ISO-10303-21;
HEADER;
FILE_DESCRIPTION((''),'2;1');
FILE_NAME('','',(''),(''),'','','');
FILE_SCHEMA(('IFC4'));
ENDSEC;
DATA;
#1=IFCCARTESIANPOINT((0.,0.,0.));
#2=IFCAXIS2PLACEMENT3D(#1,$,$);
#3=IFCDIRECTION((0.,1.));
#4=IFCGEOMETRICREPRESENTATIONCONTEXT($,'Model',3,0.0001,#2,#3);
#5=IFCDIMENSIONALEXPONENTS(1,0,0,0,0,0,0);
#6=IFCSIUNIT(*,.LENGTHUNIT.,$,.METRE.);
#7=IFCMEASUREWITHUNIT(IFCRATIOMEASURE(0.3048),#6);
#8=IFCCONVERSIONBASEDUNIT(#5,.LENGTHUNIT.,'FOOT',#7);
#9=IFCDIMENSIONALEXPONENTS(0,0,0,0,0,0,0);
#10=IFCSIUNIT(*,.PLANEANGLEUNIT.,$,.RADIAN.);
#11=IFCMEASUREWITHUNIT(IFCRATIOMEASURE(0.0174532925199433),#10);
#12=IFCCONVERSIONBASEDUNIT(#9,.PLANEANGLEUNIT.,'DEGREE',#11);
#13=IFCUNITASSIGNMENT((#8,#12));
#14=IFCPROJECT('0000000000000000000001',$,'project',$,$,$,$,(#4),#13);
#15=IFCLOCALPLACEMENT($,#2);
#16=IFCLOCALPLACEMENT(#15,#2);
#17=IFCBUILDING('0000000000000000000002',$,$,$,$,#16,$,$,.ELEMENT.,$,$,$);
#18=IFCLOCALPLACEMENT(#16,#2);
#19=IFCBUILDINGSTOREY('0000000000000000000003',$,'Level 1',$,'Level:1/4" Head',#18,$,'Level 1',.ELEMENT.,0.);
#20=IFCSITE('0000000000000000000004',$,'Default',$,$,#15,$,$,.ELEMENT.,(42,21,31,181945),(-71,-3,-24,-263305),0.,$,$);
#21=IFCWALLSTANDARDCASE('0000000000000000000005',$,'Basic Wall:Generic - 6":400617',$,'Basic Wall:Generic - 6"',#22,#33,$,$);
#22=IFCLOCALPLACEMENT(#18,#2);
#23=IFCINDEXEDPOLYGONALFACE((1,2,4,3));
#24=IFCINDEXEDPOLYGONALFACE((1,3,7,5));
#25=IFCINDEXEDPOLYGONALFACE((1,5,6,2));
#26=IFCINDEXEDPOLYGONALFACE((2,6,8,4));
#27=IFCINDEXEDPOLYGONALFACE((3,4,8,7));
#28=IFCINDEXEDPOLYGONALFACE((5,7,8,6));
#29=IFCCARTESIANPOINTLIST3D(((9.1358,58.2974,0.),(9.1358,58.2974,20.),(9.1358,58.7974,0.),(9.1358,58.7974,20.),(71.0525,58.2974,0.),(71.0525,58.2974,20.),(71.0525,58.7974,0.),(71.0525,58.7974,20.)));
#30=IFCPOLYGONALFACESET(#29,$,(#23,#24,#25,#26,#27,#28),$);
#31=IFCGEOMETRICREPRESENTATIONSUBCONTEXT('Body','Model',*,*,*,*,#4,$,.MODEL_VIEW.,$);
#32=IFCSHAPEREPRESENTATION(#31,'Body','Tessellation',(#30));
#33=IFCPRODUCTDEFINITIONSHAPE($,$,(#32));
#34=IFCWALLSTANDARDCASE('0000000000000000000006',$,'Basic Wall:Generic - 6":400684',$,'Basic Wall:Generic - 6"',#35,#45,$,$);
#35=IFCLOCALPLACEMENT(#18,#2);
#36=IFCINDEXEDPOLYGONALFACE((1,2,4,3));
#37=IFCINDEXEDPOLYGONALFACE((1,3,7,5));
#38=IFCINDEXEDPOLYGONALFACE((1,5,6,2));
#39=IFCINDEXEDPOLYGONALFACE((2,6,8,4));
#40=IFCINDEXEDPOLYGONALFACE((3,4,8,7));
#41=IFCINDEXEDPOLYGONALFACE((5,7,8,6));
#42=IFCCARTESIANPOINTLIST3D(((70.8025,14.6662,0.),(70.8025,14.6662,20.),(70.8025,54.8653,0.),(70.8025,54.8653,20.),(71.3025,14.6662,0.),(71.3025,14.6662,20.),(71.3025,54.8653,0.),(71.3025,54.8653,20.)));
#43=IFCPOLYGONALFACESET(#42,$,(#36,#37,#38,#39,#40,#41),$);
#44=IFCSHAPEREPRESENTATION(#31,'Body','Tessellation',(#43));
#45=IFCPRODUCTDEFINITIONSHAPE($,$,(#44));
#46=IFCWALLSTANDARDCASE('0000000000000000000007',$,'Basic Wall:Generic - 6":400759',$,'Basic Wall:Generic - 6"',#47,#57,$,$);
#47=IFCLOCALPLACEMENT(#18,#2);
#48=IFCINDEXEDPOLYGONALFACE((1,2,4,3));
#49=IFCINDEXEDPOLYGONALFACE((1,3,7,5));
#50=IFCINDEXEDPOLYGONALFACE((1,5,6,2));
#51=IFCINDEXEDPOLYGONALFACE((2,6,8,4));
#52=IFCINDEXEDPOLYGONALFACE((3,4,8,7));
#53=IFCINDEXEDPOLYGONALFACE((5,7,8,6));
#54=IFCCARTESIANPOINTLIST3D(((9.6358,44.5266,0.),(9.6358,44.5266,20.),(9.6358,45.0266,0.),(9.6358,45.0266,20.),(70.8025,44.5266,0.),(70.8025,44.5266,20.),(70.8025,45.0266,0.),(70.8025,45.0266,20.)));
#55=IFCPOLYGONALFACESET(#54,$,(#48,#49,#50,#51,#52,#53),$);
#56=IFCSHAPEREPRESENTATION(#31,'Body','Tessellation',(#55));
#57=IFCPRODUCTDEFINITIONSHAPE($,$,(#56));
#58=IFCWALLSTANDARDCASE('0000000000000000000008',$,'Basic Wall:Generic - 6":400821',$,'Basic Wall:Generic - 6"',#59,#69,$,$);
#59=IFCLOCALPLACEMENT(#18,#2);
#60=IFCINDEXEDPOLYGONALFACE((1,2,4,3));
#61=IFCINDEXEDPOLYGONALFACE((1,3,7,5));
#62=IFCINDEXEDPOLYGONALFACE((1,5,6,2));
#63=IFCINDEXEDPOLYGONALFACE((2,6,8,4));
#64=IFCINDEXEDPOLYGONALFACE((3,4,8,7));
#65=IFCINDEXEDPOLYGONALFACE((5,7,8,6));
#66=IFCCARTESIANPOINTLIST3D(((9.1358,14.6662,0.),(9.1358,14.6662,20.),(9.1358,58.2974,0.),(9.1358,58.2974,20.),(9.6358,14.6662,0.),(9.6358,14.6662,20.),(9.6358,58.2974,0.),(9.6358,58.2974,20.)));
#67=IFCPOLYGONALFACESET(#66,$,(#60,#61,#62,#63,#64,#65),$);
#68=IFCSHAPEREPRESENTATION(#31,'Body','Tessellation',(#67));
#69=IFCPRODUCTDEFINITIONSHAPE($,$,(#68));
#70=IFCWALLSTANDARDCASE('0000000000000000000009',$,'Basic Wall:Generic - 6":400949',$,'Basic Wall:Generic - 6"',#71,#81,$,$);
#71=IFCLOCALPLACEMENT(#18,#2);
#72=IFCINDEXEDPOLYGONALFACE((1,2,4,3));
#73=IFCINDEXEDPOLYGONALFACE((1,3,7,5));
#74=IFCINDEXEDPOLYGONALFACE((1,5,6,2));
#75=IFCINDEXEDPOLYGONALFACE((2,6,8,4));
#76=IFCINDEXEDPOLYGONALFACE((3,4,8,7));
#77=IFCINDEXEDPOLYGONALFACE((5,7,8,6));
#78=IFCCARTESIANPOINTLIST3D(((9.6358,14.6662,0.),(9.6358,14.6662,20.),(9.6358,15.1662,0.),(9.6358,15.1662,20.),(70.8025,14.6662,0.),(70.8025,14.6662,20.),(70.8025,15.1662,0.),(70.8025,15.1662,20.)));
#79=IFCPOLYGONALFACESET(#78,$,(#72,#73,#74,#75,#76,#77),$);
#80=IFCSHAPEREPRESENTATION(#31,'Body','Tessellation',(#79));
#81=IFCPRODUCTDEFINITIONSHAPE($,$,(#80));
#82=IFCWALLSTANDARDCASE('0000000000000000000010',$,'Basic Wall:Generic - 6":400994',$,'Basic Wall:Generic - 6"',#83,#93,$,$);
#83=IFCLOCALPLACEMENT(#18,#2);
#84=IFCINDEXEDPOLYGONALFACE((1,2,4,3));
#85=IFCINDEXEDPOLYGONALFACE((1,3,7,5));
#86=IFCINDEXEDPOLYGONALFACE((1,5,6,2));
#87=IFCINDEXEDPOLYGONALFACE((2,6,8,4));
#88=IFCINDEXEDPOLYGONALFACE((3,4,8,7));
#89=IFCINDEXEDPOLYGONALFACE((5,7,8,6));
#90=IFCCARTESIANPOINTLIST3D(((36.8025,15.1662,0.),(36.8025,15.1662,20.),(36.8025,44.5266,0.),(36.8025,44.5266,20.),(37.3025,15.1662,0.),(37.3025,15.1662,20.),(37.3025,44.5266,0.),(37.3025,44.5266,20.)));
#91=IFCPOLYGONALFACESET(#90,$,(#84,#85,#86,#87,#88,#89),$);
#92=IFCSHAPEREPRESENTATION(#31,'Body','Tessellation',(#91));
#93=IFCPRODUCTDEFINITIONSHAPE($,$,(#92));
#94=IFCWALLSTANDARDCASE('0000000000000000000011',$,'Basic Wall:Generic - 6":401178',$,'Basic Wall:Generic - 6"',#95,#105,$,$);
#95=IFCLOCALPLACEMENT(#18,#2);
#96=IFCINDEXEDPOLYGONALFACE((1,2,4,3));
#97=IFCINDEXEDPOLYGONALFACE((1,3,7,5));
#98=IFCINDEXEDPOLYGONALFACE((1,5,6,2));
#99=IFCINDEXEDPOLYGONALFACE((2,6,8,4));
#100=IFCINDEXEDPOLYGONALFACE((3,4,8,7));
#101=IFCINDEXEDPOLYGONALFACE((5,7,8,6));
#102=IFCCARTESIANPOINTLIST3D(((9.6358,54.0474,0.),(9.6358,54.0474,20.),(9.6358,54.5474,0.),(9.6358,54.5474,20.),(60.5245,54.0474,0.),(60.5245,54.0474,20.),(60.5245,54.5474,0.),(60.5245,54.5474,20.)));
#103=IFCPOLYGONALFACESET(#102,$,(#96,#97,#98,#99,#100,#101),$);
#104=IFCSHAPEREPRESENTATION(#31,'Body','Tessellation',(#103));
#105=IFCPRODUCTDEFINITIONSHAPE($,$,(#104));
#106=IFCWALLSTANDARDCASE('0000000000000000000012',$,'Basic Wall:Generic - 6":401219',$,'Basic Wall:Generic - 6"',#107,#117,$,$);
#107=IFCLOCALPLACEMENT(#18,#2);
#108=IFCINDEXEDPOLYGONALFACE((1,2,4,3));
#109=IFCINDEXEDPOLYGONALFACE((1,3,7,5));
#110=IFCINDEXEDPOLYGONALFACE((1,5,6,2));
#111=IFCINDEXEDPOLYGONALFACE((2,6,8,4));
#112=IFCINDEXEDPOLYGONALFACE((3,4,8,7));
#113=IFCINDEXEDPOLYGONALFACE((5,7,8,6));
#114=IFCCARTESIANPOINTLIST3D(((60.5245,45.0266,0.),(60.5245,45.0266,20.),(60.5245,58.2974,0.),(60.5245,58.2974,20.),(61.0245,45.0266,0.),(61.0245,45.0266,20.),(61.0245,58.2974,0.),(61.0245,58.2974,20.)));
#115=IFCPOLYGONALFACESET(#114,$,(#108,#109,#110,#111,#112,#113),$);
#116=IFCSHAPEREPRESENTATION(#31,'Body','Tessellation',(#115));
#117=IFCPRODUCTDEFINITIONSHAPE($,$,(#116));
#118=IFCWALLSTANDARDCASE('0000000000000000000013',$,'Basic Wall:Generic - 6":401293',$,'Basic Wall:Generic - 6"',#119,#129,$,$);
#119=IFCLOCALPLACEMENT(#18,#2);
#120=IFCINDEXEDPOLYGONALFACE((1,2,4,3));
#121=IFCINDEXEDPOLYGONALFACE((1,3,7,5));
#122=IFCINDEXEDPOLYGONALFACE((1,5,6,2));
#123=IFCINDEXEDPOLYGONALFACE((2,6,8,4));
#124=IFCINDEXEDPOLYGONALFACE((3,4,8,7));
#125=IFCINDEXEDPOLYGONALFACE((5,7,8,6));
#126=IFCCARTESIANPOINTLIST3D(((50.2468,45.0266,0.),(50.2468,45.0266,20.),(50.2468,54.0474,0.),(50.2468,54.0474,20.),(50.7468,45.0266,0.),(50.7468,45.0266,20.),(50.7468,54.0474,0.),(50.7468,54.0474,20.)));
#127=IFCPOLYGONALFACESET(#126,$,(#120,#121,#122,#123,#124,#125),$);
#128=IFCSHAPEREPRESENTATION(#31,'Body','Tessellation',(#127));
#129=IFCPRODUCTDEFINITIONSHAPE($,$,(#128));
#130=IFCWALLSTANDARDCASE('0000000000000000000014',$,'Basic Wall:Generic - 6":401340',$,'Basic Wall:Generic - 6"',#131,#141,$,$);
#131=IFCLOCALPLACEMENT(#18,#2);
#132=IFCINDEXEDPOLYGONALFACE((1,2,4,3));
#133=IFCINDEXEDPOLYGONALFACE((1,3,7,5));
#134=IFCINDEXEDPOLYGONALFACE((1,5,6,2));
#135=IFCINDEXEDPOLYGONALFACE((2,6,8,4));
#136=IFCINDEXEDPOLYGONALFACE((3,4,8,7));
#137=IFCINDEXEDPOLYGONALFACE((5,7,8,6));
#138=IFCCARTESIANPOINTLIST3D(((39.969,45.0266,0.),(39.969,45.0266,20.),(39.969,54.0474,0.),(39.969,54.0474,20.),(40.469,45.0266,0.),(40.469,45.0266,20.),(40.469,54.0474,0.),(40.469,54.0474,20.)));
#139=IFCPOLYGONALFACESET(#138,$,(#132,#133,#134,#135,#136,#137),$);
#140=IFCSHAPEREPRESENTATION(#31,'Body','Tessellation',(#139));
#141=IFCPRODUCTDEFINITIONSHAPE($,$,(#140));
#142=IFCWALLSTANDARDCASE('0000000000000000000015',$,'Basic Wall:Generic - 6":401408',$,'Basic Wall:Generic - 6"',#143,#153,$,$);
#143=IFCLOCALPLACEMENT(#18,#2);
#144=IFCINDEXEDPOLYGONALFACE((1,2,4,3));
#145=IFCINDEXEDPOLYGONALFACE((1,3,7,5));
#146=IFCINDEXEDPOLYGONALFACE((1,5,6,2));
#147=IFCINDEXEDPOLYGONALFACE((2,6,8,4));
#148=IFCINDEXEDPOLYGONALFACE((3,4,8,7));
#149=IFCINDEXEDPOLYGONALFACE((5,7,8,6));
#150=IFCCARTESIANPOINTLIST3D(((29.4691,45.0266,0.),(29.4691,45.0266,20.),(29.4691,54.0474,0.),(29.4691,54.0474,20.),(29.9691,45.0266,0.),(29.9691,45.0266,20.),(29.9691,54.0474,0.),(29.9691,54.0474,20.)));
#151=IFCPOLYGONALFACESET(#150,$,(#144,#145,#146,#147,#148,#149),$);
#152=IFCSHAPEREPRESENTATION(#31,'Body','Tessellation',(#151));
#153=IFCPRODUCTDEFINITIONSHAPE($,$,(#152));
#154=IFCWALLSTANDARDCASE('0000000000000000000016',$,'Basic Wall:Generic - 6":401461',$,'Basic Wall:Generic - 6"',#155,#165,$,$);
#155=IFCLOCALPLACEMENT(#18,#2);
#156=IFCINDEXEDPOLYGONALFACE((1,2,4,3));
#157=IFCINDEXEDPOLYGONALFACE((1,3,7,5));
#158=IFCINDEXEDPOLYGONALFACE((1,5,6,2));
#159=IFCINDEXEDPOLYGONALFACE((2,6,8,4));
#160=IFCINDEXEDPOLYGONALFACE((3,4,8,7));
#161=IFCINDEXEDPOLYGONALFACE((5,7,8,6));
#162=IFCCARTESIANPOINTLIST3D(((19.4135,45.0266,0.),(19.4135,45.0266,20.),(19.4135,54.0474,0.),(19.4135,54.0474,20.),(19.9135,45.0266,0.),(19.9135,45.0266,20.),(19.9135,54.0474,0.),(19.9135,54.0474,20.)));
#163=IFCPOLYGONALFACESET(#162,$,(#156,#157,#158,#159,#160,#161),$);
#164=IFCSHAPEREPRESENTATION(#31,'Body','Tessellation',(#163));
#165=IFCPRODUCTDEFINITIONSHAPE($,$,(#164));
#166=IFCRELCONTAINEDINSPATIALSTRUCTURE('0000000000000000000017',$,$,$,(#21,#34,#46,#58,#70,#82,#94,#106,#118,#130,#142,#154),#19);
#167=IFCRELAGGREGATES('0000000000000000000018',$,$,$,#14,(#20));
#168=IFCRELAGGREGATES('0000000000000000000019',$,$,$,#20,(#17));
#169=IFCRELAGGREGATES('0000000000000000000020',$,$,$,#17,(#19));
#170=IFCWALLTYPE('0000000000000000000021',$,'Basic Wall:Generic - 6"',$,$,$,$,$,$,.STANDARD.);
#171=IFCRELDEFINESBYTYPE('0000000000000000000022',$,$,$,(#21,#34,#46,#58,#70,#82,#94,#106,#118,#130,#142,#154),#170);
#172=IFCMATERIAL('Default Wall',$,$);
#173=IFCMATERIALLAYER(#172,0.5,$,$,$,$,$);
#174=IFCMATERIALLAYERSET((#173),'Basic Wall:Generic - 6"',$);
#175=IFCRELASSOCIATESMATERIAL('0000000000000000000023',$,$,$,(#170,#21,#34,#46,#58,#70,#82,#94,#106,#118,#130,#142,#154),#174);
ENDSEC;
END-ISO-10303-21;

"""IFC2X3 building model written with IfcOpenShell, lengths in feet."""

from ifc_helpers import new_model, entity, si_unit, converted_unit, direction, frame, frame_2d, origin, place, context, subcontext, project, spatial, rectangle, extrude, material, layer, layer_set, layer_usage, type_object, element, save


model = new_model("IFC2X3")

# Units and contexts
model_context = context("Model", 3, precision=0.0001, world=origin(), true_north=direction((0.0, 1.0)))
body_context = subcontext(model_context, "Body", "Model", "MODEL_VIEW")
ifc_project = project(units=[converted_unit("LENGTHUNIT", "FOOT", entity("IfcRatioMeasure", 0.3048), si_unit("LENGTHUNIT", "METRE"), dimensions=[1, 0, 0, 0, 0, 0, 0]), converted_unit("PLANEANGLEUNIT", "DEGREE", entity("IfcRatioMeasure", 0.0174532925199433), si_unit("PLANEANGLEUNIT", "RADIAN"), dimensions=[0, 0, 0, 0, 0, 0, 0])], contexts=[model_context])

# Site, building, storey
site_placement = place(None, origin())
site = spatial("IfcSite", under=ifc_project, at=site_placement, Name="Default", CompositionType="ELEMENT", RefLatitude=(42, 21, 31, 181945), RefLongitude=(-71, -3, -24, -263305), RefElevation=0.0)
building_placement = place(site_placement, origin())
building = spatial("IfcBuilding", under=site, at=building_placement, CompositionType="ELEMENT")
storey_placement = place(building_placement, origin())
storey = spatial("IfcBuildingStorey", under=building, at=storey_placement, Name="Level 1", ObjectType="Level:1/4\" Head", LongName="Level 1", CompositionType="ELEMENT", Elevation=0.0)

# Walls
ifc_material = material(Name="Default Wall")
ifc_layer = layer(ifc_material, 0.5)
ifc_layer_set = layer_set([ifc_layer], Name="Basic Wall:Generic - 6\"")
wall_type = type_object("IfcWallType", Name="Basic Wall:Generic - 6\"", PredefinedType="STANDARD", material=ifc_layer_set)
ifc_layer_usage_1 = layer_usage(ifc_layer_set, "AXIS2", "NEGATIVE", 0.25)
wall_1_placement = place(storey_placement, frame((9.1358, 58.5474, 0.0)))
element("IfcWallStandardCase", 1, at=wall_1_placement, inside=storey, type_object=wall_type, material=ifc_layer_usage_1, Name="Basic Wall:Generic - 6\":400617", ObjectType="Basic Wall:Generic - 6\"", context=body_context, shape_type="SweptSolid", body=[
    extrude(rectangle(XDim=61.9167, YDim=0.5, at=frame_2d((30.9583, 0.0), x_axis=(-1.0, 0.0))), origin(), (0.0, 0.0, 1.0), 20.0),
])
ifc_layer_usage_2 = layer_usage(ifc_layer_set, "AXIS2", "NEGATIVE", 0.25)
wall_2_placement = place(storey_placement, frame((71.0525, 54.8653, 0.0), z_axis=(0.0, 0.0, 1.0), x_axis=(0.0, -1.0, 0.0)))
element("IfcWallStandardCase", 2, at=wall_2_placement, inside=storey, type_object=wall_type, material=ifc_layer_usage_2, Name="Basic Wall:Generic - 6\":400684", ObjectType="Basic Wall:Generic - 6\"", context=body_context, shape_type="SweptSolid", body=[
    extrude(rectangle(XDim=40.1991, YDim=0.5, at=frame_2d((20.0995, 0.0), x_axis=(-1.0, 0.0))), origin(), (0.0, 0.0, 1.0), 20.0),
])
ifc_layer_usage_3 = layer_usage(ifc_layer_set, "AXIS2", "NEGATIVE", 0.25)
wall_3_placement = place(storey_placement, frame((70.8025, 44.7766, 0.0), z_axis=(0.0, 0.0, 1.0), x_axis=(-1.0, 0.0, 0.0)))
element("IfcWallStandardCase", 3, at=wall_3_placement, inside=storey, type_object=wall_type, material=ifc_layer_usage_3, Name="Basic Wall:Generic - 6\":400759", ObjectType="Basic Wall:Generic - 6\"", context=body_context, shape_type="SweptSolid", body=[
    extrude(rectangle(XDim=61.1667, YDim=0.5, at=frame_2d((30.5833, 0.0), x_axis=(-1.0, 0.0))), origin(), (0.0, 0.0, 1.0), 20.0),
])
ifc_layer_usage_4 = layer_usage(ifc_layer_set, "AXIS2", "NEGATIVE", 0.25)
wall_4_placement = place(storey_placement, frame((9.3858, 14.6662, 0.0), z_axis=(0.0, 0.0, 1.0), x_axis=(0.0, 1.0, 0.0)))
element("IfcWallStandardCase", 4, at=wall_4_placement, inside=storey, type_object=wall_type, material=ifc_layer_usage_4, Name="Basic Wall:Generic - 6\":400821", ObjectType="Basic Wall:Generic - 6\"", context=body_context, shape_type="SweptSolid", body=[
    extrude(rectangle(XDim=43.6312, YDim=0.5, at=frame_2d((21.8156, 0.0), x_axis=(-1.0, 0.0))), origin(), (0.0, 0.0, 1.0), 20.0),
])
ifc_layer_usage_5 = layer_usage(ifc_layer_set, "AXIS2", "NEGATIVE", 0.25)
wall_5_placement = place(storey_placement, frame((9.6358, 14.9162, 0.0)))
element("IfcWallStandardCase", 5, at=wall_5_placement, inside=storey, type_object=wall_type, material=ifc_layer_usage_5, Name="Basic Wall:Generic - 6\":400949", ObjectType="Basic Wall:Generic - 6\"", context=body_context, shape_type="SweptSolid", body=[
    extrude(rectangle(XDim=61.1667, YDim=0.5, at=frame_2d((30.5833, 0.0), x_axis=(-1.0, 0.0))), origin(), (0.0, 0.0, 1.0), 20.0),
])
ifc_layer_usage_6 = layer_usage(ifc_layer_set, "AXIS2", "NEGATIVE", 0.25)
wall_6_placement = place(storey_placement, frame((37.0525, 15.1662, 0.0), z_axis=(0.0, 0.0, 1.0), x_axis=(0.0, 1.0, 0.0)))
element("IfcWallStandardCase", 6, at=wall_6_placement, inside=storey, type_object=wall_type, material=ifc_layer_usage_6, Name="Basic Wall:Generic - 6\":400994", ObjectType="Basic Wall:Generic - 6\"", context=body_context, shape_type="SweptSolid", body=[
    extrude(rectangle(XDim=29.3604, YDim=0.5, at=frame_2d((14.6802, 0.0), x_axis=(-1.0, 0.0))), origin(), (0.0, 0.0, 1.0), 20.0),
])
ifc_layer_usage_7 = layer_usage(ifc_layer_set, "AXIS2", "NEGATIVE", 0.25)
wall_7_placement = place(storey_placement, frame((9.6358, 54.2974, 0.0)))
element("IfcWallStandardCase", 7, at=wall_7_placement, inside=storey, type_object=wall_type, material=ifc_layer_usage_7, Name="Basic Wall:Generic - 6\":401178", ObjectType="Basic Wall:Generic - 6\"", context=body_context, shape_type="SweptSolid", body=[
    extrude(rectangle(XDim=50.8888, YDim=0.5, at=frame_2d((25.4444, 0.0), x_axis=(-1.0, 0.0))), origin(), (0.0, 0.0, 1.0), 20.0),
])
ifc_layer_usage_8 = layer_usage(ifc_layer_set, "AXIS2", "NEGATIVE", 0.25)
wall_8_placement = place(storey_placement, frame((60.7745, 58.2974, 0.0), z_axis=(0.0, 0.0, 1.0), x_axis=(0.0, -1.0, 0.0)))
element("IfcWallStandardCase", 8, at=wall_8_placement, inside=storey, type_object=wall_type, material=ifc_layer_usage_8, Name="Basic Wall:Generic - 6\":401219", ObjectType="Basic Wall:Generic - 6\"", context=body_context, shape_type="SweptSolid", body=[
    extrude(rectangle(XDim=13.2708, YDim=0.5, at=frame_2d((6.6354, 0.0), x_axis=(-1.0, 0.0))), origin(), (0.0, 0.0, 1.0), 20.0),
])
ifc_layer_usage_9 = layer_usage(ifc_layer_set, "AXIS2", "NEGATIVE", 0.25)
wall_9_placement = place(storey_placement, frame((50.4968, 45.0266, 0.0), z_axis=(0.0, 0.0, 1.0), x_axis=(0.0, 1.0, 0.0)))
element("IfcWallStandardCase", 9, at=wall_9_placement, inside=storey, type_object=wall_type, material=ifc_layer_usage_9, Name="Basic Wall:Generic - 6\":401293", ObjectType="Basic Wall:Generic - 6\"", context=body_context, shape_type="SweptSolid", body=[
    extrude(rectangle(XDim=9.0208, YDim=0.5, at=frame_2d((4.5104, 0.0), x_axis=(-1.0, 0.0))), origin(), (0.0, 0.0, 1.0), 20.0),
])
ifc_layer_usage_10 = layer_usage(ifc_layer_set, "AXIS2", "NEGATIVE", 0.25)
wall_10_placement = place(storey_placement, frame((40.219, 54.0474, 0.0), z_axis=(0.0, 0.0, 1.0), x_axis=(0.0, -1.0, 0.0)))
element("IfcWallStandardCase", 10, at=wall_10_placement, inside=storey, type_object=wall_type, material=ifc_layer_usage_10, Name="Basic Wall:Generic - 6\":401340", ObjectType="Basic Wall:Generic - 6\"", context=body_context, shape_type="SweptSolid", body=[
    extrude(rectangle(XDim=9.0208, YDim=0.5, at=frame_2d((4.5104, 0.0), x_axis=(-1.0, 0.0))), origin(), (0.0, 0.0, 1.0), 20.0),
])
ifc_layer_usage_11 = layer_usage(ifc_layer_set, "AXIS2", "NEGATIVE", 0.25)
wall_11_placement = place(storey_placement, frame((29.7191, 45.0266, 0.0), z_axis=(0.0, 0.0, 1.0), x_axis=(0.0, 1.0, 0.0)))
element("IfcWallStandardCase", 11, at=wall_11_placement, inside=storey, type_object=wall_type, material=ifc_layer_usage_11, Name="Basic Wall:Generic - 6\":401408", ObjectType="Basic Wall:Generic - 6\"", context=body_context, shape_type="SweptSolid", body=[
    extrude(rectangle(XDim=9.0208, YDim=0.5, at=frame_2d((4.5104, 0.0), x_axis=(-1.0, 0.0))), origin(), (0.0, 0.0, 1.0), 20.0),
])
ifc_layer_usage_12 = layer_usage(ifc_layer_set, "AXIS2", "NEGATIVE", 0.25)
wall_12_placement = place(storey_placement, frame((19.6635, 45.0266, 0.0), z_axis=(0.0, 0.0, 1.0), x_axis=(0.0, 1.0, 0.0)))
element("IfcWallStandardCase", 12, at=wall_12_placement, inside=storey, type_object=wall_type, material=ifc_layer_usage_12, Name="Basic Wall:Generic - 6\":401461", ObjectType="Basic Wall:Generic - 6\"", context=body_context, shape_type="SweptSolid", body=[
    extrude(rectangle(XDim=9.0208, YDim=0.5, at=frame_2d((4.5104, 0.0), x_axis=(-1.0, 0.0))), origin(), (0.0, 0.0, 1.0), 20.0),
])

save(model, "model.ifc")
